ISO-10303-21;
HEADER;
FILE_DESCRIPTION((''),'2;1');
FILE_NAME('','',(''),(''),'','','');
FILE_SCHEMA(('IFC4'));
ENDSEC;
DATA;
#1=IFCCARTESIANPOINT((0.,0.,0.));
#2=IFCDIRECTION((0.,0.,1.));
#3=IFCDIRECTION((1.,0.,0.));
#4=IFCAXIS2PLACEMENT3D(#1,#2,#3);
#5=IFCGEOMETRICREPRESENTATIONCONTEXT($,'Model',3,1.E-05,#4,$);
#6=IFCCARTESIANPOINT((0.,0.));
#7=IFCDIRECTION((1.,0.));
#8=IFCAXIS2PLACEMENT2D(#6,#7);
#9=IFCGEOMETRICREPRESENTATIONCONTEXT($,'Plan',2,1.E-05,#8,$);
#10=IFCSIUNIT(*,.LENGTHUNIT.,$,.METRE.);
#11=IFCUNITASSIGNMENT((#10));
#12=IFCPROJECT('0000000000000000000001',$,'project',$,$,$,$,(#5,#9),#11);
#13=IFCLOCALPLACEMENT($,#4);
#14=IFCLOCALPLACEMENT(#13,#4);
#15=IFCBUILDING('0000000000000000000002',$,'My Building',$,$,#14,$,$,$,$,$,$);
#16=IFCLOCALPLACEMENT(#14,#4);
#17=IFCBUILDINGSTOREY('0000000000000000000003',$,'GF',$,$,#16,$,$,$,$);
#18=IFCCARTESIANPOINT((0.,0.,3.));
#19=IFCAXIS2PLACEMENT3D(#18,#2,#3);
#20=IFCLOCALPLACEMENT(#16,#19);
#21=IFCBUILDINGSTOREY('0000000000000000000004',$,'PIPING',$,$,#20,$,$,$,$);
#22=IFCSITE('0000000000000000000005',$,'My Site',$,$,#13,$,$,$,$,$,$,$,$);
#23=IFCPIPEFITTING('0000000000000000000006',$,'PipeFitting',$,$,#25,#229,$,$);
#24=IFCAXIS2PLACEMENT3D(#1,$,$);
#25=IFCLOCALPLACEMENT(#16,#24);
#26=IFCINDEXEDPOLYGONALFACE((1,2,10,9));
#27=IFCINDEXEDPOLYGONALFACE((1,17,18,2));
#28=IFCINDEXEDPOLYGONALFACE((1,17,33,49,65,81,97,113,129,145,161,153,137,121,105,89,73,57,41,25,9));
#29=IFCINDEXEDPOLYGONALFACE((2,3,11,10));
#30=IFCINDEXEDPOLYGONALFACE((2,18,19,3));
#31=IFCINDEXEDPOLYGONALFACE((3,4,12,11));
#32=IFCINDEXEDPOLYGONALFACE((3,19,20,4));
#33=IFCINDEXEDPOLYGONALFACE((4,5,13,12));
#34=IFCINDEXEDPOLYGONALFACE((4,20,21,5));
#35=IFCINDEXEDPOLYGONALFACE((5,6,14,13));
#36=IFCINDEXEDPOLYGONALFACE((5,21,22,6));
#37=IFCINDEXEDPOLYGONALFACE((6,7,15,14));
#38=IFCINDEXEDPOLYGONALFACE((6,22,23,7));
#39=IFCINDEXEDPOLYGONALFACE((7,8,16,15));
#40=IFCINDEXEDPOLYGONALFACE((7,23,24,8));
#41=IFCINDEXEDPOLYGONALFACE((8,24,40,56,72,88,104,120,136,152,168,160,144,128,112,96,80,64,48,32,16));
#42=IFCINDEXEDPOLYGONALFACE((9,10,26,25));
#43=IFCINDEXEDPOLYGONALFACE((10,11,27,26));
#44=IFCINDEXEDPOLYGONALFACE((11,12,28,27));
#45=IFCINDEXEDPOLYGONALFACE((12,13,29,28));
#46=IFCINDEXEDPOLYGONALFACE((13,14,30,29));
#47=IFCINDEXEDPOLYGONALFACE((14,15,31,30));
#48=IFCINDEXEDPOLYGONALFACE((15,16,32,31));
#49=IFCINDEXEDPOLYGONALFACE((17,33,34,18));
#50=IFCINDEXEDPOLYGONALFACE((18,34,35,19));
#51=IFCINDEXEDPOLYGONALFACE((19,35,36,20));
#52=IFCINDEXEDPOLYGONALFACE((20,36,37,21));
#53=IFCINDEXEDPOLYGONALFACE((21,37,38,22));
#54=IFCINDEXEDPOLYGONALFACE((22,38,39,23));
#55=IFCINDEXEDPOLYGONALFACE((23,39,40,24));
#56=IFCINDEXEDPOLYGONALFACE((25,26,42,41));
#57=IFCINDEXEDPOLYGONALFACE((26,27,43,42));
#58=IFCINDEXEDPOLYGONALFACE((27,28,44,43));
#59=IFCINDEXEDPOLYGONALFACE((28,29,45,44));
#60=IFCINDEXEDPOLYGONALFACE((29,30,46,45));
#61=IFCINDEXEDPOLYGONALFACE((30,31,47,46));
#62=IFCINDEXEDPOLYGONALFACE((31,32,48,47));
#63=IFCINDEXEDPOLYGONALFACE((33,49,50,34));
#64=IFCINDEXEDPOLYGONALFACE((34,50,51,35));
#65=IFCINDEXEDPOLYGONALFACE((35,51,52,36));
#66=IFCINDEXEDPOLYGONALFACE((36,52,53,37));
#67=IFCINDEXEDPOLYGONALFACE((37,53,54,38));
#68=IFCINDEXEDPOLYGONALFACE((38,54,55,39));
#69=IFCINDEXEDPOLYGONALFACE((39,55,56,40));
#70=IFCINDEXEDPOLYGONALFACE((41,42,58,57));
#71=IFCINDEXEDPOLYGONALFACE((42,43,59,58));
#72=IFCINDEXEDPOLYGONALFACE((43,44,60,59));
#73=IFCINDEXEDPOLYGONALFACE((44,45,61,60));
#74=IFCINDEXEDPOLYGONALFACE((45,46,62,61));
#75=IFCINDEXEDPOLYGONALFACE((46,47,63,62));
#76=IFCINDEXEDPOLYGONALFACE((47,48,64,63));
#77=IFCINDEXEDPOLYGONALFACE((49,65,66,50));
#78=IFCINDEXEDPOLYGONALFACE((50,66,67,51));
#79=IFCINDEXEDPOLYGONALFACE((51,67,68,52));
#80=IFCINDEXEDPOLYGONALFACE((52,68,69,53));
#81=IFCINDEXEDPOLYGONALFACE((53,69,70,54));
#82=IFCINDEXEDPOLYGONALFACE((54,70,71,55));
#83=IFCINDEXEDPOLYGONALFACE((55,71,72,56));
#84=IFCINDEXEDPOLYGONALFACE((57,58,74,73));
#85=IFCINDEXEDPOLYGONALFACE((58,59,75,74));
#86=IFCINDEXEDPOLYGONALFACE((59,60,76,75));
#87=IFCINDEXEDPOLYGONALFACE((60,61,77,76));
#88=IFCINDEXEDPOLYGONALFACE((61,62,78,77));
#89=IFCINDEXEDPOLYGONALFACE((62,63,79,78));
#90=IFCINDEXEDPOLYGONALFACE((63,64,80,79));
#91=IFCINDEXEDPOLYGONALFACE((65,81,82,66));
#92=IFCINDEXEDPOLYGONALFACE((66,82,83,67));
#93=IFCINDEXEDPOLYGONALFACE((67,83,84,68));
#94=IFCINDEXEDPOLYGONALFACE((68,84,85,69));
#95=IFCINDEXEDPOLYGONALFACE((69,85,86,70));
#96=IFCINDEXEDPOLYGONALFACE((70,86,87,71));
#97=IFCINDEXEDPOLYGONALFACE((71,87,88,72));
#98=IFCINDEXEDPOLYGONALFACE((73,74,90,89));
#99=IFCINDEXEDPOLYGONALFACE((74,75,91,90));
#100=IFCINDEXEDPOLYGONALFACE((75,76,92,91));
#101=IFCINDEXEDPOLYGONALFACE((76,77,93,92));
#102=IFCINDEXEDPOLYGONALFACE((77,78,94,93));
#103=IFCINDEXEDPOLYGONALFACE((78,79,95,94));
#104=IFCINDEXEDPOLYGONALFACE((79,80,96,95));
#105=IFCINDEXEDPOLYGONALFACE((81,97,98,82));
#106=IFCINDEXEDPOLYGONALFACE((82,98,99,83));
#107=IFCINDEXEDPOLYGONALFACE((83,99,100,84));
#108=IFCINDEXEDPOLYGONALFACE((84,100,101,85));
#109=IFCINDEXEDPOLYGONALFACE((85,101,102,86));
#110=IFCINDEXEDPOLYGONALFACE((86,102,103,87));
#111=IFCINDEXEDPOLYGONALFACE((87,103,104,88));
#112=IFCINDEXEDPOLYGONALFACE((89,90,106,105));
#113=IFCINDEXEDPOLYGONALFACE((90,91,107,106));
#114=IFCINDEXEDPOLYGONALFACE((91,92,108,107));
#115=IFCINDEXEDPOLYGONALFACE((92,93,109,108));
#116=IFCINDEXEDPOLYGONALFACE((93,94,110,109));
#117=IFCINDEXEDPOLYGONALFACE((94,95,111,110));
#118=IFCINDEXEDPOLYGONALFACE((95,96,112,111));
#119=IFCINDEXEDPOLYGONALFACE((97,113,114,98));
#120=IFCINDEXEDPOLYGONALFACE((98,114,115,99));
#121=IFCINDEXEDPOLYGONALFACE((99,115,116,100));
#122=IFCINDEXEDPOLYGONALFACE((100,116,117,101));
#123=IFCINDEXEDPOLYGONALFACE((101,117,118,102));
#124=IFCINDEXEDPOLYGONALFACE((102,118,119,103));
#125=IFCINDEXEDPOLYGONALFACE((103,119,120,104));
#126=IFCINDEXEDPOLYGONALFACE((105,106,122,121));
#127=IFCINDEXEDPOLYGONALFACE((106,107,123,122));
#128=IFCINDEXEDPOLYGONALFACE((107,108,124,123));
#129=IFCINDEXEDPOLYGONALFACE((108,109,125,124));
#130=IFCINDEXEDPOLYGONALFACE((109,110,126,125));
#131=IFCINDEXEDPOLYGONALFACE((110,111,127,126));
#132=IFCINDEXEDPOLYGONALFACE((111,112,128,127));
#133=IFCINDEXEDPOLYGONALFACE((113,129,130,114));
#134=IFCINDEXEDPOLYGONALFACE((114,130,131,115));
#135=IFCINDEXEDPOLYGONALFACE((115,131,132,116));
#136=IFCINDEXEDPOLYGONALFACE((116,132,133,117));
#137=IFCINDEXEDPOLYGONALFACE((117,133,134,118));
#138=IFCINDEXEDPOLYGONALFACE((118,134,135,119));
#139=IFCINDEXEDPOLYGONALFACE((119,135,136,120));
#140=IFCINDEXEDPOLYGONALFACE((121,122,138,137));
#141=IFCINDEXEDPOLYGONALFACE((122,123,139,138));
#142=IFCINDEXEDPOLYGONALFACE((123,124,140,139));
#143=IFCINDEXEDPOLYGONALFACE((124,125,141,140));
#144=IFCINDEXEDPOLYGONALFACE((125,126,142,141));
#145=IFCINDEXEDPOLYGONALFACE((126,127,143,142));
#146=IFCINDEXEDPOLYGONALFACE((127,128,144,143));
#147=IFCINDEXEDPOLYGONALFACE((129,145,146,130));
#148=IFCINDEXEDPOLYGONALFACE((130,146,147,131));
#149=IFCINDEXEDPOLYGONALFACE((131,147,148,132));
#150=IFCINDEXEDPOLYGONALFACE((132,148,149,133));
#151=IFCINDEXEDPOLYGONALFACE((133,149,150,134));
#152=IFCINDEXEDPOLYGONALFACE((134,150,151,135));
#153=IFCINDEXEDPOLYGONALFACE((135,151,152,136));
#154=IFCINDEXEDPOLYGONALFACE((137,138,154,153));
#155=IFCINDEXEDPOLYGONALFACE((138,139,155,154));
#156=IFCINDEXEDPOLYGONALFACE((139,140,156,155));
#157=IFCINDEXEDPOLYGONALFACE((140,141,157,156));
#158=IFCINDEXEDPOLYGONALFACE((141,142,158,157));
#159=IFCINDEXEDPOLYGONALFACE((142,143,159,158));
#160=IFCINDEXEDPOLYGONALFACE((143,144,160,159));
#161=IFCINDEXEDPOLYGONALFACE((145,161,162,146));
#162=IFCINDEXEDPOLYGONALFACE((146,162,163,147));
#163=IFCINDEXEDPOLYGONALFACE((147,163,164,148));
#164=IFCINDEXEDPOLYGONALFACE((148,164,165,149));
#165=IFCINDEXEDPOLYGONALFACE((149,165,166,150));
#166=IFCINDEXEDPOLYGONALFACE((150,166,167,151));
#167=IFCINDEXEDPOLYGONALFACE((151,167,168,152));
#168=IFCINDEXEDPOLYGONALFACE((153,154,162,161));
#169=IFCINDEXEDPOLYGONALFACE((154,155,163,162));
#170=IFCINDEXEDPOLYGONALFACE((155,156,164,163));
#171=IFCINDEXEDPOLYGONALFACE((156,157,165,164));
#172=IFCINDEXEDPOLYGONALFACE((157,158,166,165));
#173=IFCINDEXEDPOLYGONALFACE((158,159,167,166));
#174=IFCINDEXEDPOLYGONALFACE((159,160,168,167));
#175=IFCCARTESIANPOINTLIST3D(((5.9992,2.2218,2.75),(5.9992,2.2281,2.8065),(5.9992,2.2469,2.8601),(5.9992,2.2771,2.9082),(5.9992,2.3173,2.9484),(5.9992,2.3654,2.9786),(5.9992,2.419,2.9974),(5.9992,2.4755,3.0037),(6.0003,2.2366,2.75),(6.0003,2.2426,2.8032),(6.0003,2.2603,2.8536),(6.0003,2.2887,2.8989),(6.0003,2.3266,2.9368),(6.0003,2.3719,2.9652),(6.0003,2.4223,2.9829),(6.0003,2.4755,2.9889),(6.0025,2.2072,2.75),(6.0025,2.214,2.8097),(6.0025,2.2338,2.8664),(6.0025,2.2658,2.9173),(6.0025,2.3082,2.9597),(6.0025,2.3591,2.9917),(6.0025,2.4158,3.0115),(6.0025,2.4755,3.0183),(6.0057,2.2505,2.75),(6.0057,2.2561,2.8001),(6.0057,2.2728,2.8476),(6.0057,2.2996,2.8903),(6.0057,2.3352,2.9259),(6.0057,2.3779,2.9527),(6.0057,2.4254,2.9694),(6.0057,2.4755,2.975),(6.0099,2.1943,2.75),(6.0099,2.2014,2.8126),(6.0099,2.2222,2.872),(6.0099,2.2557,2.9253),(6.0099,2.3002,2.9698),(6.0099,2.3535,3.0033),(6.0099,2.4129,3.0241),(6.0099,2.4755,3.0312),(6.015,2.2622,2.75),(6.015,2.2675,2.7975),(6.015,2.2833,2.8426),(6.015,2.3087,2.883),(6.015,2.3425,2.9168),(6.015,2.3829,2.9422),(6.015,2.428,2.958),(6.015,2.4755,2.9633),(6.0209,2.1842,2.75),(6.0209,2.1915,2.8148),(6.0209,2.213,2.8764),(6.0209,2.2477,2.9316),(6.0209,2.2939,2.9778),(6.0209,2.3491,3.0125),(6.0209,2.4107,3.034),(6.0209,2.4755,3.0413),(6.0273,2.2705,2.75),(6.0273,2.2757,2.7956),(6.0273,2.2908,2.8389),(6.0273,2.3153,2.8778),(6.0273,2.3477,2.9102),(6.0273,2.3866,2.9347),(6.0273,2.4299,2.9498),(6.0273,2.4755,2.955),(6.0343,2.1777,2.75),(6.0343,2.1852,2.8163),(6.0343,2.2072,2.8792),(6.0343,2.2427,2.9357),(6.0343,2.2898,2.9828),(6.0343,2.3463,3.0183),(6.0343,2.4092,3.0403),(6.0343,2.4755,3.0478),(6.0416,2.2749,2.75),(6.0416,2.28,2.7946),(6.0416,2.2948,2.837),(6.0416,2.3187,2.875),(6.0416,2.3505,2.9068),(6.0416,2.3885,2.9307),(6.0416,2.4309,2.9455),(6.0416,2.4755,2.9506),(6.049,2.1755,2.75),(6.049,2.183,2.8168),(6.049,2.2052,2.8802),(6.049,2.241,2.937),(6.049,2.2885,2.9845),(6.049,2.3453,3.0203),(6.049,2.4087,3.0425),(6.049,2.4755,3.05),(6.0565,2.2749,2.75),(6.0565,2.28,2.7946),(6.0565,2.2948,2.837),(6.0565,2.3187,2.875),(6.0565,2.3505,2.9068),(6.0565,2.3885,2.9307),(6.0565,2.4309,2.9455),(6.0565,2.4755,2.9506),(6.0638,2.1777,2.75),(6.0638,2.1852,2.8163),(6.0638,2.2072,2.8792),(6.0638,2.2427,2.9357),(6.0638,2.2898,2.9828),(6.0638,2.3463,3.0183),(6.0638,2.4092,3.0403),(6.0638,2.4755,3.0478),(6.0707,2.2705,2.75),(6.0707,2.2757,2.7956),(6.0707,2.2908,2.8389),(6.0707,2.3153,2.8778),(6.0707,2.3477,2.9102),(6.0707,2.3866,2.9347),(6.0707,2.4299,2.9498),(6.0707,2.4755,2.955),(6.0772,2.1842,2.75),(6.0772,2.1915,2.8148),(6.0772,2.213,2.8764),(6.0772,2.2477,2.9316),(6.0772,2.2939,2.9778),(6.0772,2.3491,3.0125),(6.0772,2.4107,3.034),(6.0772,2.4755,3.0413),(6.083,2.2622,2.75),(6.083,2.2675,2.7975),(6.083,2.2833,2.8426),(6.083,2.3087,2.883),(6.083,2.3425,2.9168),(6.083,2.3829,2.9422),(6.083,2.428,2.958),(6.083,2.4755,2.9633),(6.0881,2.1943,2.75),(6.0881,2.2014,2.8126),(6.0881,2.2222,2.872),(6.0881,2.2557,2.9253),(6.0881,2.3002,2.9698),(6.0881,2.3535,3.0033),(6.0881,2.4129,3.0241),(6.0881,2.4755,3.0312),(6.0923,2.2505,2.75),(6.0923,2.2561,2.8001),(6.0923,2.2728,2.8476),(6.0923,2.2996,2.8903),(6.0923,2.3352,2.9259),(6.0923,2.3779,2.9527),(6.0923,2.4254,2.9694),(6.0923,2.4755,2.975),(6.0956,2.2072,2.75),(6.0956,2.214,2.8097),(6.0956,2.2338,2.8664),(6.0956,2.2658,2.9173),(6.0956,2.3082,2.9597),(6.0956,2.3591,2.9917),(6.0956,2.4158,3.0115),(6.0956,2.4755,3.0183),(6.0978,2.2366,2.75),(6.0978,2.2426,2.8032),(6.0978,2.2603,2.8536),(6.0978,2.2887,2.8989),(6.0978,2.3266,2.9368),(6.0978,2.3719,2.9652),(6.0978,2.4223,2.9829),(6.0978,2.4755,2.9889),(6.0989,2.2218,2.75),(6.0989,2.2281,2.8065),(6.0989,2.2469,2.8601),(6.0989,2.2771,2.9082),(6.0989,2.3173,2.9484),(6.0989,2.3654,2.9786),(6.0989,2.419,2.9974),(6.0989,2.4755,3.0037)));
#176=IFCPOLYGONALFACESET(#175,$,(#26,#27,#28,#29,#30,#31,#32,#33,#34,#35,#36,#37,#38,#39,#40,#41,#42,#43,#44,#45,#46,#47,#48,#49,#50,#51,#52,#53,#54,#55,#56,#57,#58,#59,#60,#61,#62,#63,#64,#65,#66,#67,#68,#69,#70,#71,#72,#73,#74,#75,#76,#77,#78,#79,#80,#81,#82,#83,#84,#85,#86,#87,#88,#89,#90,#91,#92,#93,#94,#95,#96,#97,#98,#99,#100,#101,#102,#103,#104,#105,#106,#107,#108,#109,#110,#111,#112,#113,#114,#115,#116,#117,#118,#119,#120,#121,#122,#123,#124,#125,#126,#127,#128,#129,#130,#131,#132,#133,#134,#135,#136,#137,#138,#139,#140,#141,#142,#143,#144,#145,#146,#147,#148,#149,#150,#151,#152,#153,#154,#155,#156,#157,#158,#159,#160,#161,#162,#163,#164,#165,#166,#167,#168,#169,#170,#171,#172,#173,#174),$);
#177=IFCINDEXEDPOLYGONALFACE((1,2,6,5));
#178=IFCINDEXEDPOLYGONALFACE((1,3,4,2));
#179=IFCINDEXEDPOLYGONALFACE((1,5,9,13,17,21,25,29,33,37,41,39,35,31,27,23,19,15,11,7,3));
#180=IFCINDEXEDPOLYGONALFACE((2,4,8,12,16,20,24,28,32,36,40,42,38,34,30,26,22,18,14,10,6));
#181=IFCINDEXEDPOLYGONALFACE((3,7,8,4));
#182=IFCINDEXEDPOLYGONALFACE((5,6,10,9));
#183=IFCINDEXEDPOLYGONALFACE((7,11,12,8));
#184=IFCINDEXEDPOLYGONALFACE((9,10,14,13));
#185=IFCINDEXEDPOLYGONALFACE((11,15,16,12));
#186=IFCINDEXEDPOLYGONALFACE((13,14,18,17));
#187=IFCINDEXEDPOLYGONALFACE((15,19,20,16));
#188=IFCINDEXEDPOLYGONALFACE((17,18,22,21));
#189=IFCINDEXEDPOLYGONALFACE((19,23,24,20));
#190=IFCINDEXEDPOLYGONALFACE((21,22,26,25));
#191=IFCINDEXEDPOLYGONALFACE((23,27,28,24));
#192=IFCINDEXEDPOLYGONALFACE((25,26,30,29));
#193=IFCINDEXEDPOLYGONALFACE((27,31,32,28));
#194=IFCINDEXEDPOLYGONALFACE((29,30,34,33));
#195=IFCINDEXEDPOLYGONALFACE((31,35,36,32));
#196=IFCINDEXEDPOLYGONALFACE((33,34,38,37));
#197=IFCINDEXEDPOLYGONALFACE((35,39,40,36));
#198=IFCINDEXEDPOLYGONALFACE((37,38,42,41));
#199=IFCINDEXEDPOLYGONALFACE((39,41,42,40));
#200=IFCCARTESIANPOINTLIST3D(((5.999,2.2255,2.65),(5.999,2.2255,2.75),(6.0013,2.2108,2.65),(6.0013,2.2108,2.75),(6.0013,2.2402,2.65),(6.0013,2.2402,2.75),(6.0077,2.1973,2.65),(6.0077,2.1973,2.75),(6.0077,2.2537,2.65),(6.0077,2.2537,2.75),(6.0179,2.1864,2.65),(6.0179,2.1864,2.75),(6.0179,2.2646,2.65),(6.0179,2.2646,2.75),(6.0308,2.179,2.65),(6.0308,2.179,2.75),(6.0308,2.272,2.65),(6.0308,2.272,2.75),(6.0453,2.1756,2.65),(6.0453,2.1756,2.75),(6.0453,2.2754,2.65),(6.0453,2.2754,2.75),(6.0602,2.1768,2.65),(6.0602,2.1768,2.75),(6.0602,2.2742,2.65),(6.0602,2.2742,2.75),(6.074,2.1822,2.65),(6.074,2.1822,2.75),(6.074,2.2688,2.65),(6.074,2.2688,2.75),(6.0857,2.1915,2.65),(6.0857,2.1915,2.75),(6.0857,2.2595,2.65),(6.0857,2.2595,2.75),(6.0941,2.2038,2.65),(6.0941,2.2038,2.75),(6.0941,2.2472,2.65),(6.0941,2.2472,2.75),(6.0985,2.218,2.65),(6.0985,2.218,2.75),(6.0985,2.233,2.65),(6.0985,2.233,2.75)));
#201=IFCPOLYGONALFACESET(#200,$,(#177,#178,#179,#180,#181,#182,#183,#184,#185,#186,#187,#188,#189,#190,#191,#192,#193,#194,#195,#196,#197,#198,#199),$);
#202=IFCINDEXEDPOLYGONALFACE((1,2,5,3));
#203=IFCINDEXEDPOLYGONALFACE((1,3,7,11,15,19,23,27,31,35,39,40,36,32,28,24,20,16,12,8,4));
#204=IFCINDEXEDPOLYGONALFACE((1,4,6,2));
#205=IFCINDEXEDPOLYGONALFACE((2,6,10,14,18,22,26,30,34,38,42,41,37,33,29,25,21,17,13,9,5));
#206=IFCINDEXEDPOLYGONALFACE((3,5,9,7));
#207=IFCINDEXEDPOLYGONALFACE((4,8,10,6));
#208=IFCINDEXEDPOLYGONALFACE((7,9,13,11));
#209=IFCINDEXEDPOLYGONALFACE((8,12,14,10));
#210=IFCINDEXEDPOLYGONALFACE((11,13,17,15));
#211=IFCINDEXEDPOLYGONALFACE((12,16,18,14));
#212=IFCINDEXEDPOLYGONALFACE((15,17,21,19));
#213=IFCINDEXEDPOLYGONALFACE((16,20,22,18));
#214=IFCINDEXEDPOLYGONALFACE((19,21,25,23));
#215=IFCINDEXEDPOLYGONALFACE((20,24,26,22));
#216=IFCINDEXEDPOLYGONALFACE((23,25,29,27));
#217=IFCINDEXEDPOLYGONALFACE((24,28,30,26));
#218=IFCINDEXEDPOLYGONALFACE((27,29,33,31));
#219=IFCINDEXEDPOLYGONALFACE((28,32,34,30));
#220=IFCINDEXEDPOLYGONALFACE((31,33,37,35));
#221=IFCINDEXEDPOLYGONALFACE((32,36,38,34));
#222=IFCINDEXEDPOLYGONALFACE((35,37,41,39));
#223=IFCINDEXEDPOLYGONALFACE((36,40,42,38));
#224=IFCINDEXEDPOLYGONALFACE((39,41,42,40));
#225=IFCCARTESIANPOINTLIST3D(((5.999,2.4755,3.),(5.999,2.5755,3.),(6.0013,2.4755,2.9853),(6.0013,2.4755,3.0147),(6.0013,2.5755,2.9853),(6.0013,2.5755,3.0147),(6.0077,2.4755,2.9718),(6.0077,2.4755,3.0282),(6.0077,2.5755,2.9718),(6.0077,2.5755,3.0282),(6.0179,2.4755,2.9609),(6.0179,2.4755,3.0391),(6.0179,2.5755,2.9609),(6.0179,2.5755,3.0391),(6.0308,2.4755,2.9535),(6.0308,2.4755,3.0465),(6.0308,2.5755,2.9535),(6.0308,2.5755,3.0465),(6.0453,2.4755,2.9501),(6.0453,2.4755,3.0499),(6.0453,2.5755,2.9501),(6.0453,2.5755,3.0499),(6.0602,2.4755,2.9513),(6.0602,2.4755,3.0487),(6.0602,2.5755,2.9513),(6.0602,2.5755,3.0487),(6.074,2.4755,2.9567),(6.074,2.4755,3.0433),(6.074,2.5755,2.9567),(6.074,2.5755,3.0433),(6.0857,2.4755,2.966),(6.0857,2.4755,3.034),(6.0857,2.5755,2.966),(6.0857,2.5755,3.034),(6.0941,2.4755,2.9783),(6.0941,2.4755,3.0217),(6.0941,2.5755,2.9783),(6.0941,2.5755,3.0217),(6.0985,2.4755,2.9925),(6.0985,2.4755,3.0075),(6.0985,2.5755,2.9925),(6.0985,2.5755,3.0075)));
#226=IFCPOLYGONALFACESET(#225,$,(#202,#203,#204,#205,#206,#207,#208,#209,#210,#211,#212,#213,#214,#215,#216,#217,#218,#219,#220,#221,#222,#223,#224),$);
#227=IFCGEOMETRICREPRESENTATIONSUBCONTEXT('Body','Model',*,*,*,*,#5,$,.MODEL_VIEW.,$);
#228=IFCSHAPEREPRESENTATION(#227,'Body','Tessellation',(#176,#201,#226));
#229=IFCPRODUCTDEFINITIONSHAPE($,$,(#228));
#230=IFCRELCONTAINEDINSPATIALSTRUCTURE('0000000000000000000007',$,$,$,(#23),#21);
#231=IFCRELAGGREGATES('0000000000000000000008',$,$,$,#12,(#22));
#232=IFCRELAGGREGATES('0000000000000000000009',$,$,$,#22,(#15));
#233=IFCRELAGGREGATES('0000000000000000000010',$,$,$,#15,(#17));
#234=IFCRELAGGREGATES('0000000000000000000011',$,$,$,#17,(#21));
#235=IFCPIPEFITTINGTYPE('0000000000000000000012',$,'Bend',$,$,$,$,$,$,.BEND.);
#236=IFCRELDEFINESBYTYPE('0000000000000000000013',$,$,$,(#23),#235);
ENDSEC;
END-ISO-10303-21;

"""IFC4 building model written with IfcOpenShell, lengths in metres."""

from ifc_helpers import new_model, entity, si_unit, frame, origin_with_axes, origin_2d_with_axis, place, context, subcontext, project, spatial, circle, extrude, source, transform, mapped, type_object, type_shapes, element, save


model = new_model("IFC4")

# Units and contexts
model_context = context("Model", 3, precision=1e-05, world=origin_with_axes())
plan_context = context("Plan", 2, precision=1e-05, world=origin_2d_with_axis())
body_context = subcontext(model_context, "Body", "Model", "MODEL_VIEW")
ifc_project = project(units=[si_unit("LENGTHUNIT", "METRE")], contexts=[model_context, plan_context])

# Site, building, storeys
site_placement = place(None, origin_with_axes())
site = spatial("IfcSite", under=ifc_project, at=site_placement, Name="My Site")
building_placement = place(site_placement, origin_with_axes())
building = spatial("IfcBuilding", under=site, at=building_placement, Name="My Building")
storey_1_placement = place(building_placement, origin_with_axes())
storey_1 = spatial("IfcBuildingStorey", under=building, at=storey_1_placement, Name="GF")
storey_2_placement = place(storey_1_placement, frame((0.0, 0.0, 3.0), z_axis=(0.0, 0.0, 1.0), x_axis=(1.0, 0.0, 0.0)))
storey_2 = spatial("IfcBuildingStorey", under=storey_1, at=storey_2_placement, Name="PIPING")

# Pipe fitting
pipe_fitting_type = type_object("IfcPipeFittingType", Name="Bend", PredefinedType="BEND")
shared_shape = source(origin_with_axes(), body_context, "Body", "SolidModel", [
    entity("IfcSweptDiskSolid", entity("IfcIndexedPolyCurve", entity("IfcCartesianPointList3D", [[0.0, 0.0, -0.1], [0.0, 0.0732, -0.2768], [0.0, 0.25, -0.35]]), [entity("IfcArcIndex", [1, 2, 3])]), 0.05),
    extrude(circle(Radius=0.05), origin_with_axes(), (0.0, 0.0, -1.0), 0.1),
    extrude(circle(Radius=0.05), frame((0.0, 0.25, -0.35), z_axis=(0.0, 1.0, 0.0), x_axis=(1.0, 0.0, 0.0)), (0.0, 0.0, 1.0), 0.1),
])
type_shapes(pipe_fitting_type, [shared_shape])
for number, where, z_axis, x_axis, name in (
    (1, (6.049, 2.2255, -0.35), (0.0, 0.0, -1.0), (-1.0, 0.0, 0.0), "PipeFitting"),
):
    element("IfcPipeFitting", number, at=place(storey_2_placement, frame(where, z_axis=z_axis, x_axis=x_axis)), inside=storey_2, type_object=pipe_fitting_type, Name=name, context=body_context, shape_type="MappedRepresentation", body=[
        mapped(shared_shape, transform((0.0, 0.0, 0.0), x_axis=(1.0, 0.0, 0.0), y_axis=(0.0, 1.0, 0.0), z_axis=(0.0, 0.0, 1.0), scale=1.0)),
    ])

save(model, "model.ifc")
